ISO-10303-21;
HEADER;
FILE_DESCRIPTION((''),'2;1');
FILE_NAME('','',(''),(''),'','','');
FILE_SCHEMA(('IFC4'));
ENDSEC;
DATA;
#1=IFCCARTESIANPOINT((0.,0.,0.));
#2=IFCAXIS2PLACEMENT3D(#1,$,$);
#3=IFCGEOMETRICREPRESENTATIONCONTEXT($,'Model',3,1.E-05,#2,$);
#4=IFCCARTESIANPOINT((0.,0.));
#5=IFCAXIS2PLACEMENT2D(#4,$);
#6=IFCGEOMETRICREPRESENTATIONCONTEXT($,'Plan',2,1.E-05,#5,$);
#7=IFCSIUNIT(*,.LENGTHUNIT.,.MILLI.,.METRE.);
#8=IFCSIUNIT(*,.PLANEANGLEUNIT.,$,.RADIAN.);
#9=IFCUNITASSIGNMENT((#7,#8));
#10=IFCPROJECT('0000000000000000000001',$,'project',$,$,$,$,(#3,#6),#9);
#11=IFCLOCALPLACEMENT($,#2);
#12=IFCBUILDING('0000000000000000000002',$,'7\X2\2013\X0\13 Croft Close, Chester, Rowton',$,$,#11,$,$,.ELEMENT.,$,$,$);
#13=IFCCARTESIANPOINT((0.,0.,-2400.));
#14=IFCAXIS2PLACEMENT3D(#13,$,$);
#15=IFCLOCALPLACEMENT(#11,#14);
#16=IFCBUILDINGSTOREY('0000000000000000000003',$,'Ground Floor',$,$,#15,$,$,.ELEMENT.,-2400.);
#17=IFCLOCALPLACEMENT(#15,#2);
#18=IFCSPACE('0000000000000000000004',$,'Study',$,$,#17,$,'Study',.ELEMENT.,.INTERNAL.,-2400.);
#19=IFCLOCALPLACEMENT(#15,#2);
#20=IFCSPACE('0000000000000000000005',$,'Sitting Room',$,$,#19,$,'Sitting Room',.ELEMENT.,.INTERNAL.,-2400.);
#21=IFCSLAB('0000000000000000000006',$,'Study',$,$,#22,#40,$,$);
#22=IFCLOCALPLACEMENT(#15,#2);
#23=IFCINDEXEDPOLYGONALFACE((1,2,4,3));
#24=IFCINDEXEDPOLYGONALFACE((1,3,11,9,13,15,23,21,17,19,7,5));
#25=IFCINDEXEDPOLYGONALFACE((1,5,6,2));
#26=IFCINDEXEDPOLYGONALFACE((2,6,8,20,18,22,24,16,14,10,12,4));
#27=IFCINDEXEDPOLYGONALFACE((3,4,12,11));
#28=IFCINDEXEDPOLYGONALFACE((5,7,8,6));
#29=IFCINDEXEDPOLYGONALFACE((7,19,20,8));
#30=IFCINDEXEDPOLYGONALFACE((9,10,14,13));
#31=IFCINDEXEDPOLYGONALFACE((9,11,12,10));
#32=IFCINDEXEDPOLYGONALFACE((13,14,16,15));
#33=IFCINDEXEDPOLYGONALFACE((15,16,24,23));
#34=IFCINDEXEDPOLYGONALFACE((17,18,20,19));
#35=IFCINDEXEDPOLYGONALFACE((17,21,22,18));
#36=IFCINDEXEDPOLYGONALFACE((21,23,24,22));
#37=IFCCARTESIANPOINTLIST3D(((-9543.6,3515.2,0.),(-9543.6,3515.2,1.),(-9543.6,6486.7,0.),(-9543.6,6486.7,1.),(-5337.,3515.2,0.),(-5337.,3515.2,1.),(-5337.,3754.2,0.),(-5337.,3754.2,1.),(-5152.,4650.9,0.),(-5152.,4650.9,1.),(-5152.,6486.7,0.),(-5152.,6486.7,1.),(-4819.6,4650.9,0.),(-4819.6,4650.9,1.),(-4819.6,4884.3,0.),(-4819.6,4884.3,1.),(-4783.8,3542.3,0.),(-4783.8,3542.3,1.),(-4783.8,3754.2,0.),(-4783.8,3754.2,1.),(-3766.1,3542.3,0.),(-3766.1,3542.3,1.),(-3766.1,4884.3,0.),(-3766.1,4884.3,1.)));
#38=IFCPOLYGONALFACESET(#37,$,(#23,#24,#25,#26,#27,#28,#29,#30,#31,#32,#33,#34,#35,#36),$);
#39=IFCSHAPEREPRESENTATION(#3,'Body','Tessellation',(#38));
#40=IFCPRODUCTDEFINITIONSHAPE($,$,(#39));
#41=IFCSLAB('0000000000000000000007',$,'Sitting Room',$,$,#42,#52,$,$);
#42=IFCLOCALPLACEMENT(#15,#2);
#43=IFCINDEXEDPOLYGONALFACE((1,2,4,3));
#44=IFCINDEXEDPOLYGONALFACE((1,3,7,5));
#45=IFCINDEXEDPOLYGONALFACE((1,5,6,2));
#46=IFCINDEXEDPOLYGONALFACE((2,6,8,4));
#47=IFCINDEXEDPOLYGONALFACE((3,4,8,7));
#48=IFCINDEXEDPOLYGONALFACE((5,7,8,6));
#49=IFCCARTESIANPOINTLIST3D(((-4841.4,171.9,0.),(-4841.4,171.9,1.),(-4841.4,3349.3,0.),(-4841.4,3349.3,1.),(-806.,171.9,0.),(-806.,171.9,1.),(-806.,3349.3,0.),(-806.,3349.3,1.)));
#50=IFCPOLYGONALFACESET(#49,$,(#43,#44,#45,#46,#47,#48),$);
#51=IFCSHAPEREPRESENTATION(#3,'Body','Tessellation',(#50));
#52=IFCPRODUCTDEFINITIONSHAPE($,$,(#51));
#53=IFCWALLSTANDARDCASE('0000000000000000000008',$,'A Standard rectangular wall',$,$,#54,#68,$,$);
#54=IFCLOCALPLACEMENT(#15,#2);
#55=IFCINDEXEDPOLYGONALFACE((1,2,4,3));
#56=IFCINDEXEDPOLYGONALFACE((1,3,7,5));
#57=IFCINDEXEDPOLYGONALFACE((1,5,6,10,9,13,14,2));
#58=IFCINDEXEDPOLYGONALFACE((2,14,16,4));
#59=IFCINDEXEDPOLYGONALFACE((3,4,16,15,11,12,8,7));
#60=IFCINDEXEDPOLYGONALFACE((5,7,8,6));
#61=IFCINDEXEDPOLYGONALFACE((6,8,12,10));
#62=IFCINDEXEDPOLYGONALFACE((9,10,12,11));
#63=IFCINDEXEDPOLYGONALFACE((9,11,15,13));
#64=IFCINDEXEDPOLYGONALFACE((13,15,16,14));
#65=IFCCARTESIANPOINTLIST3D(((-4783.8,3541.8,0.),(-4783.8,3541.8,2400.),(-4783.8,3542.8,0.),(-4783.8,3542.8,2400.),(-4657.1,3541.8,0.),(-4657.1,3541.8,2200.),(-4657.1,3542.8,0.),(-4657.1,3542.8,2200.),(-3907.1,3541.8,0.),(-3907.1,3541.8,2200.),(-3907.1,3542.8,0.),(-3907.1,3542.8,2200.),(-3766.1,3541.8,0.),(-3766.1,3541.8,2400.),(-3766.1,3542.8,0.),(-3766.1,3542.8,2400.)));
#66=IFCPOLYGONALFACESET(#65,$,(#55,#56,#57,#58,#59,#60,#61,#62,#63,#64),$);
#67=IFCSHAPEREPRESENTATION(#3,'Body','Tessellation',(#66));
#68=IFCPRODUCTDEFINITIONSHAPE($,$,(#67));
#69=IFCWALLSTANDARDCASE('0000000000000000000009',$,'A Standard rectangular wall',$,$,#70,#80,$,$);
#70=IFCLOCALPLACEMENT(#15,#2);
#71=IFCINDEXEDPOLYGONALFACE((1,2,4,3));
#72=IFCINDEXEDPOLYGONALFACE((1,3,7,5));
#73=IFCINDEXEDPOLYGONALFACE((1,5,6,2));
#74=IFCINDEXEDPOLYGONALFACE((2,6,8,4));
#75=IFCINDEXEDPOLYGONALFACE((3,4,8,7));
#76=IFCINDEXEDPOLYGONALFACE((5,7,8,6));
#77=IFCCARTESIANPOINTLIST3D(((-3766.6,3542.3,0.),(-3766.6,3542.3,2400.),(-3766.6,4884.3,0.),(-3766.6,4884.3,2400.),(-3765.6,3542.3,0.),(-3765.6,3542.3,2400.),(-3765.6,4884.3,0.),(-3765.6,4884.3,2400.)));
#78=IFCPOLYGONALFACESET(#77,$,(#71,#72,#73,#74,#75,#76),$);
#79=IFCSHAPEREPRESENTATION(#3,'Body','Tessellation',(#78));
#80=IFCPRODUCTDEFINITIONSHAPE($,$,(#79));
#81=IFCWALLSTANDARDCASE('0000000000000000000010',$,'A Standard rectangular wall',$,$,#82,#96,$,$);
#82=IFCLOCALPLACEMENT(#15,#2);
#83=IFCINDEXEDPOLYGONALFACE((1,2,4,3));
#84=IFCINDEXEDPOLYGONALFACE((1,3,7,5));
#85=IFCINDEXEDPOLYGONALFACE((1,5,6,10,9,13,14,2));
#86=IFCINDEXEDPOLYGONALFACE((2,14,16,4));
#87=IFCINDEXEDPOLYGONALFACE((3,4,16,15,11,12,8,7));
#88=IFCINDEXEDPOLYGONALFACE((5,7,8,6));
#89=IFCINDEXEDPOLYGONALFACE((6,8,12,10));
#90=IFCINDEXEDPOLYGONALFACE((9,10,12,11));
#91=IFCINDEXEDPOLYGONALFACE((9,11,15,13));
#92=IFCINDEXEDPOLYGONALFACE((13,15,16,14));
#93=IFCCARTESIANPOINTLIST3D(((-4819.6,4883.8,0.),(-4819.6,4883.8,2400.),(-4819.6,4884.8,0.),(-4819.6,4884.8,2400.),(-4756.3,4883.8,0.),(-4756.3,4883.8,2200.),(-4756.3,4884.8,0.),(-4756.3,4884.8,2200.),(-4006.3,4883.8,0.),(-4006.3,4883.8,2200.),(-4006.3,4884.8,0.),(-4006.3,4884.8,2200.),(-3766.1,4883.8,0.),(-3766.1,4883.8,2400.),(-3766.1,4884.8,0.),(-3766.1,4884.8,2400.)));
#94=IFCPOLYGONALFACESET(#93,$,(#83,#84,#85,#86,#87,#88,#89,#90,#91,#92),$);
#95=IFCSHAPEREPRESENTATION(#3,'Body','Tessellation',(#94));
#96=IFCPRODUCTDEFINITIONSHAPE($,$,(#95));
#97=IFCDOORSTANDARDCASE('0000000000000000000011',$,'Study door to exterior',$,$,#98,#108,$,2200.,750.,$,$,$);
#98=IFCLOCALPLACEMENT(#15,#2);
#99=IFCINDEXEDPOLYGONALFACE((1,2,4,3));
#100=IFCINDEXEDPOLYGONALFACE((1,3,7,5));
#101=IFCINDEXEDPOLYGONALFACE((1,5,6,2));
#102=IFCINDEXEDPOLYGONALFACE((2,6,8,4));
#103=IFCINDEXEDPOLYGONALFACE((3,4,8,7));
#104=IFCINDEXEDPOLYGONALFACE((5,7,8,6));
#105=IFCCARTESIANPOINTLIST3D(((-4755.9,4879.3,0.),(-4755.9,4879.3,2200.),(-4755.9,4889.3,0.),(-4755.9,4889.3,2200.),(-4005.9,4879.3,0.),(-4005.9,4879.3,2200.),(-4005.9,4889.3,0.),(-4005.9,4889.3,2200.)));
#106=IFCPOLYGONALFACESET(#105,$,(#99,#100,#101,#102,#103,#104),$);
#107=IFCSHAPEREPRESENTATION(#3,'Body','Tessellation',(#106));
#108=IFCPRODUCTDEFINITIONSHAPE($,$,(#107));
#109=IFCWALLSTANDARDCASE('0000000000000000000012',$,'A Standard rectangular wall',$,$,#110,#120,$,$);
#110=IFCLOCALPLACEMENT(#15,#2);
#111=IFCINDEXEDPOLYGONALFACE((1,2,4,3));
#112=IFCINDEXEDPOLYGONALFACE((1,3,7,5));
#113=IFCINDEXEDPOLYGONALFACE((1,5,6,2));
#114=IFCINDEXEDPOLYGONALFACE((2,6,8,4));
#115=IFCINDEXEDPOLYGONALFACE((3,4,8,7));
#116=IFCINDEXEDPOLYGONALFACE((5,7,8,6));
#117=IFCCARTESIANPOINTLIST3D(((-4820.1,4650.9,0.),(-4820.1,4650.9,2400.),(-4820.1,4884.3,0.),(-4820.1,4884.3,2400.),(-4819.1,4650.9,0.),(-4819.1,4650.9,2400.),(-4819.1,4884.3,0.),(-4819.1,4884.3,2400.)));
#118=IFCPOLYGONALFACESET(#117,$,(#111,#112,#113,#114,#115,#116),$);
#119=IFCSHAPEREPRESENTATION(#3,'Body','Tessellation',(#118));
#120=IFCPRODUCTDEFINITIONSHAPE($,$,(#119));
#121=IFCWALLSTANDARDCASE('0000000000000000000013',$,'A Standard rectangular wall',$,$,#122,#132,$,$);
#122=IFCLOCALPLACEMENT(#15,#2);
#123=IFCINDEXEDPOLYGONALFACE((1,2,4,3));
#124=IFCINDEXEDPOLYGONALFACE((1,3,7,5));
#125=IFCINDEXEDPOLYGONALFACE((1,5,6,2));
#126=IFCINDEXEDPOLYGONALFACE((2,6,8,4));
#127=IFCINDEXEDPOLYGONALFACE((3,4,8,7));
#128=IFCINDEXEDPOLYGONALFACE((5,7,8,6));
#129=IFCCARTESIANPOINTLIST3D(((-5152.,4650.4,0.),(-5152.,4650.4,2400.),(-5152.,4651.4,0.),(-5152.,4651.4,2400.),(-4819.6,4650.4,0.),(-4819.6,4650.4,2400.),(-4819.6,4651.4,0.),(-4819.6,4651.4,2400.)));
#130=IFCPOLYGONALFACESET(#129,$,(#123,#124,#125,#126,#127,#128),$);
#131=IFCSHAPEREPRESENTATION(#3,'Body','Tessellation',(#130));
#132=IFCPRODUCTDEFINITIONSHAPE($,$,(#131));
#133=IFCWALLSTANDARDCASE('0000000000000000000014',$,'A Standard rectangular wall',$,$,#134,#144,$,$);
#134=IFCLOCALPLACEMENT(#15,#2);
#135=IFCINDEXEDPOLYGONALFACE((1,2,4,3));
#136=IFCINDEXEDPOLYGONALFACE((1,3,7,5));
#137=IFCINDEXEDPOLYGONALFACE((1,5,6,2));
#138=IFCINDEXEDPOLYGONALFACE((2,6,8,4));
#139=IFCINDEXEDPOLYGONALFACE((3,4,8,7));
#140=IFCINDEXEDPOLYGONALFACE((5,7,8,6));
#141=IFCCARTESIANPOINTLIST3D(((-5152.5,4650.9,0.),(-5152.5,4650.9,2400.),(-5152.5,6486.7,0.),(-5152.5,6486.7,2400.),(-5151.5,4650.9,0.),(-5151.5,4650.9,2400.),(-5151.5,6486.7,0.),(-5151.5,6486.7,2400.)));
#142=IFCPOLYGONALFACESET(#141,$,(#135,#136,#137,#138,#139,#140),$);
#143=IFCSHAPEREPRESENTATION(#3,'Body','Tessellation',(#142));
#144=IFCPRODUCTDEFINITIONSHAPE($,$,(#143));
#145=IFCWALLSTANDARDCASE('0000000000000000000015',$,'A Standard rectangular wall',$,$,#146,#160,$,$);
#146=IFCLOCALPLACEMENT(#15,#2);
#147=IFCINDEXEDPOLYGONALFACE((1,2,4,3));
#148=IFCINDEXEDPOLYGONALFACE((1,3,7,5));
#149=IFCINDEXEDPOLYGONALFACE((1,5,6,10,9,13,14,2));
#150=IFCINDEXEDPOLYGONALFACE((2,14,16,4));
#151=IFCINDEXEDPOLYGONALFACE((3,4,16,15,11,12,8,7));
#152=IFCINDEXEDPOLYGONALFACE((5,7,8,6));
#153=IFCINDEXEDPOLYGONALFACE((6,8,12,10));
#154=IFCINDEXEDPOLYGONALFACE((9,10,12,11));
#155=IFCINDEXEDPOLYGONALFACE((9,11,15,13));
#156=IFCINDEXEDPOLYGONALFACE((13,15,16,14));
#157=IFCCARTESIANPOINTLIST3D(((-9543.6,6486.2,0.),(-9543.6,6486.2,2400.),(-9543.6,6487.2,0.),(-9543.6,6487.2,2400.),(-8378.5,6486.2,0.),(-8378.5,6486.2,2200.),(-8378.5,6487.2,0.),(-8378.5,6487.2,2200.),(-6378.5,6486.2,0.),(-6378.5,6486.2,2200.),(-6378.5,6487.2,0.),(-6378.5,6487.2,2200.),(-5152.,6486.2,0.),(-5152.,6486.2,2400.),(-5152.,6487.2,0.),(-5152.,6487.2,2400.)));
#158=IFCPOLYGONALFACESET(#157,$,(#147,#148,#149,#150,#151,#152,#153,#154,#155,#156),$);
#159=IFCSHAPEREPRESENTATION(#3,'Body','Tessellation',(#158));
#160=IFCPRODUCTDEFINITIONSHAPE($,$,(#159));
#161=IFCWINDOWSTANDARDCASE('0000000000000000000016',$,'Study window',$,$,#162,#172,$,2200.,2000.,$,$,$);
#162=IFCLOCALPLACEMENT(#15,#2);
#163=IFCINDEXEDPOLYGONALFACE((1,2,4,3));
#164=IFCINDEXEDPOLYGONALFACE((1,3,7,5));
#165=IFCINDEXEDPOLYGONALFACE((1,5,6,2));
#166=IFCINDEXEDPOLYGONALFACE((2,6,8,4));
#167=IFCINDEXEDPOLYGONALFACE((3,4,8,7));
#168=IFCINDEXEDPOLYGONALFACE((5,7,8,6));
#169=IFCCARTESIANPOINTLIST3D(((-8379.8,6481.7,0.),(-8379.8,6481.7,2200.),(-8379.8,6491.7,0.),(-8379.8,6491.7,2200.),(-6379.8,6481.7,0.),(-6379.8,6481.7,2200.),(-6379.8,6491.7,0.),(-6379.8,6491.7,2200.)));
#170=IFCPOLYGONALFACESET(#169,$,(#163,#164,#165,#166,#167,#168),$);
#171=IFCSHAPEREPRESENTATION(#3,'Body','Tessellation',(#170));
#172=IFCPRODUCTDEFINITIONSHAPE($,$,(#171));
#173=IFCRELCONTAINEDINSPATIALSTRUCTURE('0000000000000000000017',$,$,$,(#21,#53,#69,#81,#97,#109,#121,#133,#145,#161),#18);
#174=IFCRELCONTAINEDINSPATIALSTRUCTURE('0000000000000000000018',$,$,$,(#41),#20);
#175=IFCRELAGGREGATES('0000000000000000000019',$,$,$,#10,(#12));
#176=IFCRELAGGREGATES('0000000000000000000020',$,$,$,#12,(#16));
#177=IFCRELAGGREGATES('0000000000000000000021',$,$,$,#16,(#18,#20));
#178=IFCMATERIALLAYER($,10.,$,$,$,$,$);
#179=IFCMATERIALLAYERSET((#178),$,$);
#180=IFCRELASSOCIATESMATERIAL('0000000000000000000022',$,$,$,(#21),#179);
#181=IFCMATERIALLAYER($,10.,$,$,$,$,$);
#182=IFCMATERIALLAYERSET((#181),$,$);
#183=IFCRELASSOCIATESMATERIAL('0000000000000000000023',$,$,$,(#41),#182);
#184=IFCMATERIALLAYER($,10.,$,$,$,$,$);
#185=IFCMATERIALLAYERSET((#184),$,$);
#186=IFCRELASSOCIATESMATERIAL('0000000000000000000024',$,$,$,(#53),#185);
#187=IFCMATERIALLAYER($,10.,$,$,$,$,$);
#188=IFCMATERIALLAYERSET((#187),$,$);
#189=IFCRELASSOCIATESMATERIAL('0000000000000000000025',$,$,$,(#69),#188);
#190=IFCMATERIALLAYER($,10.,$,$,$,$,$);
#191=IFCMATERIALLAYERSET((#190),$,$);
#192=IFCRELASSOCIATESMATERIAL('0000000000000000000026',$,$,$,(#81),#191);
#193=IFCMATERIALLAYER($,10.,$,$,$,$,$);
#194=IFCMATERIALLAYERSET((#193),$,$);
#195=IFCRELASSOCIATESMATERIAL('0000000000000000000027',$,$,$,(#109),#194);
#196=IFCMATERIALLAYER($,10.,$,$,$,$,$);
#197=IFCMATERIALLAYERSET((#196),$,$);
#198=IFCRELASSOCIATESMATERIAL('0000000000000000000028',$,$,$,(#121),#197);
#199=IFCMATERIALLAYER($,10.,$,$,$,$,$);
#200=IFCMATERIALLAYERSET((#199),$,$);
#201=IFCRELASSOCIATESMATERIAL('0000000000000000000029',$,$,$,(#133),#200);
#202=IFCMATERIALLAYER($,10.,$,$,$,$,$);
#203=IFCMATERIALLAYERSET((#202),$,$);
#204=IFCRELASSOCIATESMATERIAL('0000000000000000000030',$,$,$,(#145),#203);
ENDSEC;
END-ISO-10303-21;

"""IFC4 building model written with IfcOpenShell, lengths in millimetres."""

from ifc_helpers import new_model, si_unit, frame, origin, origin_2d, place, context, project, spatial, polyline, rectangle, outline, extrude, layer, layer_set, layer_usage, element, fill, save


model = new_model("IFC4")

# Units and contexts
model_context = context("Model", 3, precision=1e-05, world=origin())
plan_context = context("Plan", 2, precision=1e-05, world=origin_2d())
ifc_project = project(units=[si_unit("LENGTHUNIT", "METRE", prefix="MILLI"), si_unit("PLANEANGLEUNIT", "RADIAN")], contexts=[model_context, plan_context])

# Building, storey, space
building_placement = place(None, origin())
building = spatial("IfcBuilding", under=ifc_project, at=building_placement, Name="7–13 Croft Close, Chester, Rowton", CompositionType="ELEMENT")
storey_placement = place(building_placement, frame((0.0, 0.0, -2400.0)))
storey = spatial("IfcBuildingStorey", under=building, at=storey_placement, Name="Ground Floor", CompositionType="ELEMENT", Elevation=-2400.0)
space_1_placement = place(storey_placement, origin())
space_1 = spatial("IfcSpace", under=storey, at=space_1_placement, Name="Study", LongName="Study", CompositionType="ELEMENT", PredefinedType="INTERNAL", ElevationWithFlooring=-2400.0)

# Slab
ifc_layer_1 = layer(None, 10.0)
ifc_layer_set_1 = layer_set([ifc_layer_1])
ifc_layer_usage_1 = layer_usage(ifc_layer_set_1, "AXIS2", "NEGATIVE", 150.0)
slab_1_placement = place(storey_placement, origin())
element("IfcSlab", 1, at=slab_1_placement, inside=space_1, material=ifc_layer_usage_1, Name="Study", context=model_context, shape_type="SweptSolid", body=[
    extrude(outline(polyline([(-4783.8, 3754.2), (-4783.8, 3542.3), (-3766.1, 3542.3), (-3766.1, 4884.3), (-4819.6, 4884.3), (-4819.6, 4650.9), (-5152.0, 4650.9), (-5152.0, 6486.7), (-9543.6, 6486.7), (-9543.6, 3515.2), (-5337.0, 3515.2), (-5337.0, 3754.2), (-4783.8, 3754.2)])), origin(), (0.0, 0.0, 1.0), 1.0),
])

# Shared definitions
space_2_placement = place(storey_placement, origin())
space_2 = spatial("IfcSpace", under=storey, at=space_2_placement, Name="Sitting Room", LongName="Sitting Room", CompositionType="ELEMENT", PredefinedType="INTERNAL", ElevationWithFlooring=-2400.0)

# Slab
ifc_layer_2 = layer(None, 10.0)
ifc_layer_set_2 = layer_set([ifc_layer_2])
ifc_layer_usage_2 = layer_usage(ifc_layer_set_2, "AXIS2", "NEGATIVE", 150.0)
slab_2_placement = place(storey_placement, origin())
element("IfcSlab", 2, at=slab_2_placement, inside=space_2, material=ifc_layer_usage_2, Name="Sitting Room", context=model_context, shape_type="SweptSolid", body=[
    extrude(outline(polyline([(-4841.4, 3349.3), (-4841.4, 171.9), (-806.0, 171.9), (-806.0, 3349.3), (-4841.4, 3349.3)])), origin(), (0.0, 0.0, 1.0), 1.0),
])

# Wall, opening
ifc_layer_3 = layer(None, 10.0)
ifc_layer_set_3 = layer_set([ifc_layer_3])
ifc_layer_usage_3 = layer_usage(ifc_layer_set_3, "AXIS2", "NEGATIVE", 150.0)
wall_1_placement = place(storey_placement, origin())
wall_1 = element("IfcWallStandardCase", 3, at=wall_1_placement, inside=space_1, material=ifc_layer_usage_3, Name="A Standard rectangular wall", context=model_context, shape_type="SweptSolid", body=[
    extrude(rectangle(XDim=1.0, YDim=1017.7, at=origin_2d()), frame((-4275.0, 3542.3, 0.0), x_axis=(0.0, 1.0, 0.0)), (0.0, 0.0, 1.0), 2400.0),
])
opening_1_placement = place(storey_placement, origin())
element("IfcOpeningElement", 4, at=opening_1_placement, cuts=wall_1, context=model_context, shape_type="SweptSolid", body=[
    extrude(rectangle(XDim=10.0, YDim=750.0, at=origin_2d()), frame((-4282.1, 3542.3, 0.0), x_axis=(0.0, -1.0, 0.0)), (0.0, 0.0, 1.0), 2200.0),
])

# Wall
ifc_layer_4 = layer(None, 10.0)
ifc_layer_set_4 = layer_set([ifc_layer_4])
ifc_layer_usage_4 = layer_usage(ifc_layer_set_4, "AXIS2", "NEGATIVE", 150.0)
wall_2_placement = place(storey_placement, origin())
element("IfcWallStandardCase", 5, at=wall_2_placement, inside=space_1, material=ifc_layer_usage_4, Name="A Standard rectangular wall", context=model_context, shape_type="SweptSolid", body=[
    extrude(rectangle(XDim=1.0, YDim=1342.0, at=origin_2d()), frame((-3766.1, 4213.3, 0.0), x_axis=(-1.0, 0.0, 0.0)), (0.0, 0.0, 1.0), 2400.0),
])

# Wall, opening, door
ifc_layer_5 = layer(None, 10.0)
ifc_layer_set_5 = layer_set([ifc_layer_5])
ifc_layer_usage_5 = layer_usage(ifc_layer_set_5, "AXIS2", "NEGATIVE", 150.0)
wall_3_placement = place(storey_placement, origin())
wall_3 = element("IfcWallStandardCase", 6, at=wall_3_placement, inside=space_1, material=ifc_layer_usage_5, Name="A Standard rectangular wall", context=model_context, shape_type="SweptSolid", body=[
    extrude(rectangle(XDim=1.0, YDim=1053.5, at=origin_2d()), frame((-4292.9, 4884.3, 0.0), x_axis=(0.0, -1.0, 0.0)), (0.0, 0.0, 1.0), 2400.0),
])
opening_2_placement = place(storey_placement, origin())
opening_2 = element("IfcOpeningElement", 7, at=opening_2_placement, cuts=wall_3, context=model_context, shape_type="SweptSolid", body=[
    extrude(rectangle(XDim=10.0, YDim=750.0, at=origin_2d()), frame((-4381.3, 4884.3, 0.0), x_axis=(0.0, 1.0, 0.0)), (0.0, 0.0, 1.0), 2200.0),
])
door_1_placement = place(storey_placement, frame((0.4, 0.0, 0.0)))
door_1 = element("IfcDoorStandardCase", 8, at=door_1_placement, inside=space_1, Name="Study door to exterior", OverallHeight=2200.0, OverallWidth=750.0, context=model_context, shape_type="SweptSolid", body=[
    extrude(rectangle(XDim=10.0, YDim=750.0, at=origin_2d()), frame((-4381.3, 4884.3, 0.0), x_axis=(0.0, 1.0, 0.0)), (0.0, 0.0, 1.0), 2200.0),
])
fill(opening_2, door_1)

# Walls
ifc_layer_6 = layer(None, 10.0)
ifc_layer_set_6 = layer_set([ifc_layer_6])
ifc_layer_usage_6 = layer_usage(ifc_layer_set_6, "AXIS2", "NEGATIVE", 150.0)
wall_4_placement = place(storey_placement, origin())
element("IfcWallStandardCase", 9, at=wall_4_placement, inside=space_1, material=ifc_layer_usage_6, Name="A Standard rectangular wall", context=model_context, shape_type="SweptSolid", body=[
    extrude(rectangle(XDim=1.0, YDim=233.4, at=origin_2d()), frame((-4819.6, 4767.6, 0.0), x_axis=(1.0, 0.0, 0.0)), (0.0, 0.0, 1.0), 2400.0),
])
ifc_layer_7 = layer(None, 10.0)
ifc_layer_set_7 = layer_set([ifc_layer_7])
ifc_layer_usage_7 = layer_usage(ifc_layer_set_7, "AXIS2", "NEGATIVE", 150.0)
wall_5_placement = place(storey_placement, origin())
element("IfcWallStandardCase", 10, at=wall_5_placement, inside=space_1, material=ifc_layer_usage_7, Name="A Standard rectangular wall", context=model_context, shape_type="SweptSolid", body=[
    extrude(rectangle(XDim=1.0, YDim=332.4, at=origin_2d()), frame((-4985.8, 4650.9, 0.0), x_axis=(0.0, -1.0, 0.0)), (0.0, 0.0, 1.0), 2400.0),
])
ifc_layer_8 = layer(None, 10.0)
ifc_layer_set_8 = layer_set([ifc_layer_8])
ifc_layer_usage_8 = layer_usage(ifc_layer_set_8, "AXIS2", "NEGATIVE", 150.0)
wall_6_placement = place(storey_placement, origin())
element("IfcWallStandardCase", 11, at=wall_6_placement, inside=space_1, material=ifc_layer_usage_8, Name="A Standard rectangular wall", context=model_context, shape_type="SweptSolid", body=[
    extrude(rectangle(XDim=1.0, YDim=1835.8, at=origin_2d()), frame((-5152.0, 5568.8, 0.0), x_axis=(-1.0, 0.0, 0.0)), (0.0, 0.0, 1.0), 2400.0),
])

# Wall, opening, window
ifc_layer_9 = layer(None, 10.0)
ifc_layer_set_9 = layer_set([ifc_layer_9])
ifc_layer_usage_9 = layer_usage(ifc_layer_set_9, "AXIS2", "NEGATIVE", 150.0)
wall_7_placement = place(storey_placement, origin())
wall_7 = element("IfcWallStandardCase", 12, at=wall_7_placement, inside=space_1, material=ifc_layer_usage_9, Name="A Standard rectangular wall", context=model_context, shape_type="SweptSolid", body=[
    extrude(rectangle(XDim=1.0, YDim=4391.6, at=origin_2d()), frame((-7347.8, 6486.7, 0.0), x_axis=(0.0, -1.0, 0.0)), (0.0, 0.0, 1.0), 2400.0),
])
opening_3_placement = place(storey_placement, origin())
opening_3 = element("IfcOpeningElement", 13, at=opening_3_placement, cuts=wall_7, context=model_context, shape_type="SweptSolid", body=[
    extrude(rectangle(XDim=10.0, YDim=2000.0, at=origin_2d()), frame((-7378.5, 6486.7, 0.0), x_axis=(0.0, -1.0, 0.0)), (0.0, 0.0, 1.0), 2200.0),
])
window_1_placement = place(storey_placement, frame((-1.3, 0.0, 0.0)))
window_1 = element("IfcWindowStandardCase", 14, at=window_1_placement, inside=space_1, Name="Study window", OverallHeight=2200.0, OverallWidth=2000.0, context=model_context, shape_type="SweptSolid", body=[
    extrude(rectangle(XDim=10.0, YDim=2000.0, at=origin_2d()), frame((-7378.5, 6486.7, 0.0), x_axis=(0.0, -1.0, 0.0)), (0.0, 0.0, 1.0), 2200.0),
])
fill(opening_3, window_1)

save(model, "model.ifc")
